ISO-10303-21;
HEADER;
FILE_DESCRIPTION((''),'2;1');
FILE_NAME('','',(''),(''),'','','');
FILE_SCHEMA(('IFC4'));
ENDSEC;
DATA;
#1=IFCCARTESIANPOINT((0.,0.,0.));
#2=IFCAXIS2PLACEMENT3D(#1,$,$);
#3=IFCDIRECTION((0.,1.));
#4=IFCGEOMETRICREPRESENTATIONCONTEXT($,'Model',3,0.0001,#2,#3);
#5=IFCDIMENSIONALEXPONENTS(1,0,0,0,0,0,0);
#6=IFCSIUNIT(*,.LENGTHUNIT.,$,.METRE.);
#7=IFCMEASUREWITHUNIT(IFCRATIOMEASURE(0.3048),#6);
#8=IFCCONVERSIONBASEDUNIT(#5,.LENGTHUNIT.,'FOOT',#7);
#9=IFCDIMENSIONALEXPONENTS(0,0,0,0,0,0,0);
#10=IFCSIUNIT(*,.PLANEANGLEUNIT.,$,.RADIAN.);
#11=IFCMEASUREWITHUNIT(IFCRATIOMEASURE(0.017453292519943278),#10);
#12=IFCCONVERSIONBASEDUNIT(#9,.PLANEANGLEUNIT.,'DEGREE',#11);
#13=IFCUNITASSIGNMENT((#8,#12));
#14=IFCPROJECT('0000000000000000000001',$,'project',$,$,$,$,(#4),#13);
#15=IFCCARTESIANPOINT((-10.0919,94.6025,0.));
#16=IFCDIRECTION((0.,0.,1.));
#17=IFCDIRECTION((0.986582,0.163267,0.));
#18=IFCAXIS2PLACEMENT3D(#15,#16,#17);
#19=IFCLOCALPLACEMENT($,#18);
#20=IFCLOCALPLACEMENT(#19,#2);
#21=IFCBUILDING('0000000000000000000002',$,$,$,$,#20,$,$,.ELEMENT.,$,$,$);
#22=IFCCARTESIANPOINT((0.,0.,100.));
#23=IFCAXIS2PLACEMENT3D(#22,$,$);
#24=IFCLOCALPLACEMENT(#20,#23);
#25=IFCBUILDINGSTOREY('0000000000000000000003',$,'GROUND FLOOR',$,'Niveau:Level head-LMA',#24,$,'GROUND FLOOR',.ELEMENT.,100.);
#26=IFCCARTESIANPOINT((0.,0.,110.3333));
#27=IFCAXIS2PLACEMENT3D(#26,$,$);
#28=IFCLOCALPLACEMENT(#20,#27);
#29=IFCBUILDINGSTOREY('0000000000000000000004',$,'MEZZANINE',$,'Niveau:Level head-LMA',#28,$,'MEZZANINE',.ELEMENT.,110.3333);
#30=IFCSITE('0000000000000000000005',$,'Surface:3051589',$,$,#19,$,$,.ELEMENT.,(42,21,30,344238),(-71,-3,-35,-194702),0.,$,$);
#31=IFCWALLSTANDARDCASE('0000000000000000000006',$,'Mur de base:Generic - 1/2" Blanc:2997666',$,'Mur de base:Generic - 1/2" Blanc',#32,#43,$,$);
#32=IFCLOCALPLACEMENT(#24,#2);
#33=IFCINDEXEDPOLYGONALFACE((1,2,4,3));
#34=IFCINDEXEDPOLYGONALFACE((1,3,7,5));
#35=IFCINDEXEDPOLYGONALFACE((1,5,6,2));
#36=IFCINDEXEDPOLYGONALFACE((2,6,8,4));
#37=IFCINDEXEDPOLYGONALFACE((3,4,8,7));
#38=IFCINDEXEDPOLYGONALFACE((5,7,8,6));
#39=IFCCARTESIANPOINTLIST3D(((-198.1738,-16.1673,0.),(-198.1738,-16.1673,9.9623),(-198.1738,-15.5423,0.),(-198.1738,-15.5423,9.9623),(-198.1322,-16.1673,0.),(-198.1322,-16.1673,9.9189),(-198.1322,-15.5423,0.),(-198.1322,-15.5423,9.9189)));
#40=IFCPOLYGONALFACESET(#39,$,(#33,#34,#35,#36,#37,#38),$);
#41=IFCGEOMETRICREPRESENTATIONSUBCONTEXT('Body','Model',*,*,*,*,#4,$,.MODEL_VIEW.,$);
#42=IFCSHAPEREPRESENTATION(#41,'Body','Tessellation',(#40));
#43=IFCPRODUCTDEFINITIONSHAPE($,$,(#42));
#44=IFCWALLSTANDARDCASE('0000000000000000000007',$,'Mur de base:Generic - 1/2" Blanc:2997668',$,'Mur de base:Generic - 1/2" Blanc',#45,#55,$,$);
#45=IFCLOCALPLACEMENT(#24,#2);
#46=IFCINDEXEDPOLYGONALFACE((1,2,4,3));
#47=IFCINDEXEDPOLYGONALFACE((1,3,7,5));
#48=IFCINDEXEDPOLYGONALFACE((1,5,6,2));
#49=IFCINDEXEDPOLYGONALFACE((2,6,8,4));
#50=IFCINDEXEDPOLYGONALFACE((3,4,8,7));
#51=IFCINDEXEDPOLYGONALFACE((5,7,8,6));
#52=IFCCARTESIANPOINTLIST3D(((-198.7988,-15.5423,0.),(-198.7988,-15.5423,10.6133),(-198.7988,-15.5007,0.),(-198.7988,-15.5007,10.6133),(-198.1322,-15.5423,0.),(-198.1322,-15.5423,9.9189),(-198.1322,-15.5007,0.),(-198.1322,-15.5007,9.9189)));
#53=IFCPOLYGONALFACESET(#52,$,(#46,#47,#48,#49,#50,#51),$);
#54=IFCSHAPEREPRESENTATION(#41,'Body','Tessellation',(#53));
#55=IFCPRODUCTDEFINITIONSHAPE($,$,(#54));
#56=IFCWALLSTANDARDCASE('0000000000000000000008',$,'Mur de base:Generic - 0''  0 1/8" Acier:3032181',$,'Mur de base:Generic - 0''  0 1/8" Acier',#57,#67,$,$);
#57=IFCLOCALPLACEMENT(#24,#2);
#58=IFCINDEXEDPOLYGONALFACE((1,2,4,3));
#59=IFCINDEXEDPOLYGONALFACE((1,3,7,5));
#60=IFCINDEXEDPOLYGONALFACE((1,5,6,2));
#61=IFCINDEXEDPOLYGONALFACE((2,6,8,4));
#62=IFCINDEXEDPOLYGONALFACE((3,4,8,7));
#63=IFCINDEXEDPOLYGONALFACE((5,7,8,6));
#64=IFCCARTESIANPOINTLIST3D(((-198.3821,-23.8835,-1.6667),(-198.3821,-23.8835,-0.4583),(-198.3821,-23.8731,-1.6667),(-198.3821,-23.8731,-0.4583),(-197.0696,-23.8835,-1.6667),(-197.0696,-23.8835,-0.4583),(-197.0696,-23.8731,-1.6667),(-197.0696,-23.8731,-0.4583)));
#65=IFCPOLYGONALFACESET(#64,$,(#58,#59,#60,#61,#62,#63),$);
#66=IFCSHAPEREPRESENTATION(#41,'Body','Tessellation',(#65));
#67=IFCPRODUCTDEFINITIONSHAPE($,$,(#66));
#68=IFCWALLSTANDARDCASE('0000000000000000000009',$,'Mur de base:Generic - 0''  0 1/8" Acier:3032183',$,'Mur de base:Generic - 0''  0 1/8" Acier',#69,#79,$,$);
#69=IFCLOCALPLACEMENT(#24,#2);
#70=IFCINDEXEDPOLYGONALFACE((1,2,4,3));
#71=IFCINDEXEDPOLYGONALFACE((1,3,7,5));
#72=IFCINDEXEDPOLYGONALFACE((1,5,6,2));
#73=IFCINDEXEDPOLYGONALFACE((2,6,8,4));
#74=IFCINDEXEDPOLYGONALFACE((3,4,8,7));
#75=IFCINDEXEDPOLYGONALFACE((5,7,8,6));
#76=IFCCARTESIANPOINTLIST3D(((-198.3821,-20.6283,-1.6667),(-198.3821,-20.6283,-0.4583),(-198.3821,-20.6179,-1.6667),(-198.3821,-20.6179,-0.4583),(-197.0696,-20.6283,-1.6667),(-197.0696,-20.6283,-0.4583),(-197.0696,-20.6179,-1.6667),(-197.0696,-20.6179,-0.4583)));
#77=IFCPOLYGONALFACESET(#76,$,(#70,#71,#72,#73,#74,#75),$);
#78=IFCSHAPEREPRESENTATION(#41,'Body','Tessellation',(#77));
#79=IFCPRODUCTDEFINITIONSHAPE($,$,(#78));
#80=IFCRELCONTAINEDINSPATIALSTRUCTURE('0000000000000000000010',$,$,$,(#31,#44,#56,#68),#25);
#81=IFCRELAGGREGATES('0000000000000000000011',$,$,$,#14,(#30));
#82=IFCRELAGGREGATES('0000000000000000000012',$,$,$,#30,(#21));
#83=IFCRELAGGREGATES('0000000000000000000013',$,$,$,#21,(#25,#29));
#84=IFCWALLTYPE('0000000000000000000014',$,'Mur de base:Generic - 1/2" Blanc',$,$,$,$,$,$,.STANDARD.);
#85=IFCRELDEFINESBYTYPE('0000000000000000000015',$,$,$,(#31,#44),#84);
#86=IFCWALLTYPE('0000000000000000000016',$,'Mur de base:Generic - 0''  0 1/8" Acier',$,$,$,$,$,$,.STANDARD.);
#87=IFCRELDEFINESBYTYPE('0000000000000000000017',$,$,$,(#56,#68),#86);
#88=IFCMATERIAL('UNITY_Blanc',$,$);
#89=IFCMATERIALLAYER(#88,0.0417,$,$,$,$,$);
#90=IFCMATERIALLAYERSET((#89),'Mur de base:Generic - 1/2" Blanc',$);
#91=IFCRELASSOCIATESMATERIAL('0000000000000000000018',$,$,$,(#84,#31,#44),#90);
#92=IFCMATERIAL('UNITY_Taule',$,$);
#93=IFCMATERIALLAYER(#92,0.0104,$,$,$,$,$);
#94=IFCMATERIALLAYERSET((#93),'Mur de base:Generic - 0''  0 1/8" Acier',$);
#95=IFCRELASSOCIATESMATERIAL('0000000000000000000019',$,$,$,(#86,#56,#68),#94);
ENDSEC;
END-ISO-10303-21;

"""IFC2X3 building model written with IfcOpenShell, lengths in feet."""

from ifc_helpers import new_model, entity, si_unit, converted_unit, direction, frame, frame_2d, origin, place, context, subcontext, project, spatial, polyline, rectangle, extrude, clip, bounded_halfspace, material, layer, layer_set, layer_usage, type_object, element, save


model = new_model("IFC2X3")

# Units and contexts
model_context = context("Model", 3, precision=0.0001, world=origin(), true_north=direction((0.0, 1.0)))
body_context = subcontext(model_context, "Body", "Model", "MODEL_VIEW")
ifc_project = project(units=[converted_unit("LENGTHUNIT", "FOOT", entity("IfcRatioMeasure", 0.3048), si_unit("LENGTHUNIT", "METRE"), dimensions=[1, 0, 0, 0, 0, 0, 0]), converted_unit("PLANEANGLEUNIT", "DEGREE", entity("IfcRatioMeasure", 0.017453292519943278), si_unit("PLANEANGLEUNIT", "RADIAN"), dimensions=[0, 0, 0, 0, 0, 0, 0])], contexts=[model_context])

# Site, building, storey
site_placement = place(None, frame((-10.0919, 94.6025, 0.0), z_axis=(0.0, 0.0, 1.0), x_axis=(0.986582, 0.163267, 0.0)))
site = spatial("IfcSite", under=ifc_project, at=site_placement, Name="Surface:3051589", CompositionType="ELEMENT", RefLatitude=(42, 21, 30, 344238), RefLongitude=(-71, -3, -35, -194702), RefElevation=0.0)
building_placement = place(site_placement, origin())
building = spatial("IfcBuilding", under=site, at=building_placement, CompositionType="ELEMENT")
storey_1_placement = place(building_placement, frame((0.0, 0.0, 100.0)))
storey_1 = spatial("IfcBuildingStorey", under=building, at=storey_1_placement, Name="GROUND FLOOR", ObjectType="Niveau:Level head-LMA", LongName="GROUND FLOOR", CompositionType="ELEMENT", Elevation=100.0)

# Shared definitions
storey_2_placement = place(building_placement, frame((0.0, 0.0, 110.3333)))
storey_2 = spatial("IfcBuildingStorey", under=building, at=storey_2_placement, Name="MEZZANINE", ObjectType="Niveau:Level head-LMA", LongName="MEZZANINE", CompositionType="ELEMENT", Elevation=110.3333)

# Walls
ifc_material_1 = material(Name="UNITY_Blanc")
ifc_layer_1 = layer(ifc_material_1, 0.0417)
ifc_layer_set_1 = layer_set([ifc_layer_1], Name="Mur de base:Generic - 1/2\" Blanc")
ifc_layer_usage_1 = layer_usage(ifc_layer_set_1, "AXIS2", "POSITIVE", -0.0208)
wall_type_1 = type_object("IfcWallType", Name="Mur de base:Generic - 1/2\" Blanc", PredefinedType="STANDARD", material=ifc_layer_set_1)
wall_1_placement = place(storey_1_placement, frame((-198.153, -16.1673, 0.0), z_axis=(0.0, 0.0, 1.0), x_axis=(0.0, 1.0, 0.0)))
element("IfcWallStandardCase", 1, at=wall_1_placement, inside=storey_1, type_object=wall_type_1, material=ifc_layer_usage_1, Name="Mur de base:Generic - 1/2\" Blanc:2997666", ObjectType="Mur de base:Generic - 1/2\" Blanc", context=body_context, shape_type="Clipping", body=[
    clip(extrude(rectangle(XDim=0.625, YDim=0.0417, at=frame_2d((0.3125, 0.0), x_axis=(-1.0, 0.0))), origin(), (0.0, 0.0, 1.0), 9.9623), bounded_halfspace(frame((0.0, -0.0208, 9.9189), z_axis=(0.0, -0.721387, 0.692532), x_axis=(1.0, 0.0, 0.0)), False, frame((0.0, -0.0208, 9.9189)), polyline([(0.0, 0.0), (0.625, 0.0), (0.625, 0.0417), (0.0, 0.0417), (0.0, 0.0)]))),
])
ifc_layer_usage_2 = layer_usage(ifc_layer_set_1, "AXIS2", "POSITIVE", -0.0208)
wall_2_placement = place(storey_1_placement, frame((-198.1322, -15.5215, 0.0), z_axis=(0.0, 0.0, 1.0), x_axis=(-1.0, 0.0, 0.0)))
element("IfcWallStandardCase", 2, at=wall_2_placement, inside=storey_1, type_object=wall_type_1, material=ifc_layer_usage_2, Name="Mur de base:Generic - 1/2\" Blanc:2997668", ObjectType="Mur de base:Generic - 1/2\" Blanc", context=body_context, shape_type="Clipping", body=[
    clip(extrude(rectangle(XDim=0.6667, YDim=0.0417, at=frame_2d((0.3333, 0.0), x_axis=(-1.0, 0.0))), origin(), (0.0, 0.0, 1.0), 10.6133), bounded_halfspace(frame((0.0, -0.0208, 9.9189), z_axis=(-0.721387, 0.0, 0.692532), x_axis=(0.0, -1.0, 0.0)), False, frame((0.0, -0.0208, 9.9189)), polyline([(0.0, 0.0), (0.6667, 0.0), (0.6667, 0.0417), (0.0417, 0.0417), (0.0, 0.0417), (0.0, 0.0)]))),
])
ifc_material_2 = material(Name="UNITY_Taule")
ifc_layer_2 = layer(ifc_material_2, 0.0104)
ifc_layer_set_2 = layer_set([ifc_layer_2], Name="Mur de base:Generic - 0'  0 1/8\" Acier")
wall_type_2 = type_object("IfcWallType", Name="Mur de base:Generic - 0'  0 1/8\" Acier", PredefinedType="STANDARD", material=ifc_layer_set_2)
ifc_layer_usage_3 = layer_usage(ifc_layer_set_2, "AXIS2", "NEGATIVE", 0.0052)
wall_3_placement = place(storey_1_placement, frame((-198.3821, -23.8783, -1.6667)))
element("IfcWallStandardCase", 3, at=wall_3_placement, inside=storey_1, type_object=wall_type_2, material=ifc_layer_usage_3, Name="Mur de base:Generic - 0'  0 1/8\" Acier:3032181", ObjectType="Mur de base:Generic - 0'  0 1/8\" Acier", context=body_context, shape_type="SweptSolid", body=[
    extrude(rectangle(XDim=1.3126, YDim=0.0104, at=frame_2d((0.6563, 0.0), x_axis=(-1.0, 0.0))), origin(), (0.0, 0.0, 1.0), 1.2083),
])
ifc_layer_usage_4 = layer_usage(ifc_layer_set_2, "AXIS2", "POSITIVE", -0.0052)
wall_4_placement = place(storey_1_placement, frame((-198.3821, -20.6231, -1.6667)))
element("IfcWallStandardCase", 4, at=wall_4_placement, inside=storey_1, type_object=wall_type_2, material=ifc_layer_usage_4, Name="Mur de base:Generic - 0'  0 1/8\" Acier:3032183", ObjectType="Mur de base:Generic - 0'  0 1/8\" Acier", context=body_context, shape_type="SweptSolid", body=[
    extrude(rectangle(XDim=1.3126, YDim=0.0104, at=frame_2d((0.6563, 0.0), x_axis=(-1.0, 0.0))), origin(), (0.0, 0.0, 1.0), 1.2083),
])

save(model, "model.ifc")
